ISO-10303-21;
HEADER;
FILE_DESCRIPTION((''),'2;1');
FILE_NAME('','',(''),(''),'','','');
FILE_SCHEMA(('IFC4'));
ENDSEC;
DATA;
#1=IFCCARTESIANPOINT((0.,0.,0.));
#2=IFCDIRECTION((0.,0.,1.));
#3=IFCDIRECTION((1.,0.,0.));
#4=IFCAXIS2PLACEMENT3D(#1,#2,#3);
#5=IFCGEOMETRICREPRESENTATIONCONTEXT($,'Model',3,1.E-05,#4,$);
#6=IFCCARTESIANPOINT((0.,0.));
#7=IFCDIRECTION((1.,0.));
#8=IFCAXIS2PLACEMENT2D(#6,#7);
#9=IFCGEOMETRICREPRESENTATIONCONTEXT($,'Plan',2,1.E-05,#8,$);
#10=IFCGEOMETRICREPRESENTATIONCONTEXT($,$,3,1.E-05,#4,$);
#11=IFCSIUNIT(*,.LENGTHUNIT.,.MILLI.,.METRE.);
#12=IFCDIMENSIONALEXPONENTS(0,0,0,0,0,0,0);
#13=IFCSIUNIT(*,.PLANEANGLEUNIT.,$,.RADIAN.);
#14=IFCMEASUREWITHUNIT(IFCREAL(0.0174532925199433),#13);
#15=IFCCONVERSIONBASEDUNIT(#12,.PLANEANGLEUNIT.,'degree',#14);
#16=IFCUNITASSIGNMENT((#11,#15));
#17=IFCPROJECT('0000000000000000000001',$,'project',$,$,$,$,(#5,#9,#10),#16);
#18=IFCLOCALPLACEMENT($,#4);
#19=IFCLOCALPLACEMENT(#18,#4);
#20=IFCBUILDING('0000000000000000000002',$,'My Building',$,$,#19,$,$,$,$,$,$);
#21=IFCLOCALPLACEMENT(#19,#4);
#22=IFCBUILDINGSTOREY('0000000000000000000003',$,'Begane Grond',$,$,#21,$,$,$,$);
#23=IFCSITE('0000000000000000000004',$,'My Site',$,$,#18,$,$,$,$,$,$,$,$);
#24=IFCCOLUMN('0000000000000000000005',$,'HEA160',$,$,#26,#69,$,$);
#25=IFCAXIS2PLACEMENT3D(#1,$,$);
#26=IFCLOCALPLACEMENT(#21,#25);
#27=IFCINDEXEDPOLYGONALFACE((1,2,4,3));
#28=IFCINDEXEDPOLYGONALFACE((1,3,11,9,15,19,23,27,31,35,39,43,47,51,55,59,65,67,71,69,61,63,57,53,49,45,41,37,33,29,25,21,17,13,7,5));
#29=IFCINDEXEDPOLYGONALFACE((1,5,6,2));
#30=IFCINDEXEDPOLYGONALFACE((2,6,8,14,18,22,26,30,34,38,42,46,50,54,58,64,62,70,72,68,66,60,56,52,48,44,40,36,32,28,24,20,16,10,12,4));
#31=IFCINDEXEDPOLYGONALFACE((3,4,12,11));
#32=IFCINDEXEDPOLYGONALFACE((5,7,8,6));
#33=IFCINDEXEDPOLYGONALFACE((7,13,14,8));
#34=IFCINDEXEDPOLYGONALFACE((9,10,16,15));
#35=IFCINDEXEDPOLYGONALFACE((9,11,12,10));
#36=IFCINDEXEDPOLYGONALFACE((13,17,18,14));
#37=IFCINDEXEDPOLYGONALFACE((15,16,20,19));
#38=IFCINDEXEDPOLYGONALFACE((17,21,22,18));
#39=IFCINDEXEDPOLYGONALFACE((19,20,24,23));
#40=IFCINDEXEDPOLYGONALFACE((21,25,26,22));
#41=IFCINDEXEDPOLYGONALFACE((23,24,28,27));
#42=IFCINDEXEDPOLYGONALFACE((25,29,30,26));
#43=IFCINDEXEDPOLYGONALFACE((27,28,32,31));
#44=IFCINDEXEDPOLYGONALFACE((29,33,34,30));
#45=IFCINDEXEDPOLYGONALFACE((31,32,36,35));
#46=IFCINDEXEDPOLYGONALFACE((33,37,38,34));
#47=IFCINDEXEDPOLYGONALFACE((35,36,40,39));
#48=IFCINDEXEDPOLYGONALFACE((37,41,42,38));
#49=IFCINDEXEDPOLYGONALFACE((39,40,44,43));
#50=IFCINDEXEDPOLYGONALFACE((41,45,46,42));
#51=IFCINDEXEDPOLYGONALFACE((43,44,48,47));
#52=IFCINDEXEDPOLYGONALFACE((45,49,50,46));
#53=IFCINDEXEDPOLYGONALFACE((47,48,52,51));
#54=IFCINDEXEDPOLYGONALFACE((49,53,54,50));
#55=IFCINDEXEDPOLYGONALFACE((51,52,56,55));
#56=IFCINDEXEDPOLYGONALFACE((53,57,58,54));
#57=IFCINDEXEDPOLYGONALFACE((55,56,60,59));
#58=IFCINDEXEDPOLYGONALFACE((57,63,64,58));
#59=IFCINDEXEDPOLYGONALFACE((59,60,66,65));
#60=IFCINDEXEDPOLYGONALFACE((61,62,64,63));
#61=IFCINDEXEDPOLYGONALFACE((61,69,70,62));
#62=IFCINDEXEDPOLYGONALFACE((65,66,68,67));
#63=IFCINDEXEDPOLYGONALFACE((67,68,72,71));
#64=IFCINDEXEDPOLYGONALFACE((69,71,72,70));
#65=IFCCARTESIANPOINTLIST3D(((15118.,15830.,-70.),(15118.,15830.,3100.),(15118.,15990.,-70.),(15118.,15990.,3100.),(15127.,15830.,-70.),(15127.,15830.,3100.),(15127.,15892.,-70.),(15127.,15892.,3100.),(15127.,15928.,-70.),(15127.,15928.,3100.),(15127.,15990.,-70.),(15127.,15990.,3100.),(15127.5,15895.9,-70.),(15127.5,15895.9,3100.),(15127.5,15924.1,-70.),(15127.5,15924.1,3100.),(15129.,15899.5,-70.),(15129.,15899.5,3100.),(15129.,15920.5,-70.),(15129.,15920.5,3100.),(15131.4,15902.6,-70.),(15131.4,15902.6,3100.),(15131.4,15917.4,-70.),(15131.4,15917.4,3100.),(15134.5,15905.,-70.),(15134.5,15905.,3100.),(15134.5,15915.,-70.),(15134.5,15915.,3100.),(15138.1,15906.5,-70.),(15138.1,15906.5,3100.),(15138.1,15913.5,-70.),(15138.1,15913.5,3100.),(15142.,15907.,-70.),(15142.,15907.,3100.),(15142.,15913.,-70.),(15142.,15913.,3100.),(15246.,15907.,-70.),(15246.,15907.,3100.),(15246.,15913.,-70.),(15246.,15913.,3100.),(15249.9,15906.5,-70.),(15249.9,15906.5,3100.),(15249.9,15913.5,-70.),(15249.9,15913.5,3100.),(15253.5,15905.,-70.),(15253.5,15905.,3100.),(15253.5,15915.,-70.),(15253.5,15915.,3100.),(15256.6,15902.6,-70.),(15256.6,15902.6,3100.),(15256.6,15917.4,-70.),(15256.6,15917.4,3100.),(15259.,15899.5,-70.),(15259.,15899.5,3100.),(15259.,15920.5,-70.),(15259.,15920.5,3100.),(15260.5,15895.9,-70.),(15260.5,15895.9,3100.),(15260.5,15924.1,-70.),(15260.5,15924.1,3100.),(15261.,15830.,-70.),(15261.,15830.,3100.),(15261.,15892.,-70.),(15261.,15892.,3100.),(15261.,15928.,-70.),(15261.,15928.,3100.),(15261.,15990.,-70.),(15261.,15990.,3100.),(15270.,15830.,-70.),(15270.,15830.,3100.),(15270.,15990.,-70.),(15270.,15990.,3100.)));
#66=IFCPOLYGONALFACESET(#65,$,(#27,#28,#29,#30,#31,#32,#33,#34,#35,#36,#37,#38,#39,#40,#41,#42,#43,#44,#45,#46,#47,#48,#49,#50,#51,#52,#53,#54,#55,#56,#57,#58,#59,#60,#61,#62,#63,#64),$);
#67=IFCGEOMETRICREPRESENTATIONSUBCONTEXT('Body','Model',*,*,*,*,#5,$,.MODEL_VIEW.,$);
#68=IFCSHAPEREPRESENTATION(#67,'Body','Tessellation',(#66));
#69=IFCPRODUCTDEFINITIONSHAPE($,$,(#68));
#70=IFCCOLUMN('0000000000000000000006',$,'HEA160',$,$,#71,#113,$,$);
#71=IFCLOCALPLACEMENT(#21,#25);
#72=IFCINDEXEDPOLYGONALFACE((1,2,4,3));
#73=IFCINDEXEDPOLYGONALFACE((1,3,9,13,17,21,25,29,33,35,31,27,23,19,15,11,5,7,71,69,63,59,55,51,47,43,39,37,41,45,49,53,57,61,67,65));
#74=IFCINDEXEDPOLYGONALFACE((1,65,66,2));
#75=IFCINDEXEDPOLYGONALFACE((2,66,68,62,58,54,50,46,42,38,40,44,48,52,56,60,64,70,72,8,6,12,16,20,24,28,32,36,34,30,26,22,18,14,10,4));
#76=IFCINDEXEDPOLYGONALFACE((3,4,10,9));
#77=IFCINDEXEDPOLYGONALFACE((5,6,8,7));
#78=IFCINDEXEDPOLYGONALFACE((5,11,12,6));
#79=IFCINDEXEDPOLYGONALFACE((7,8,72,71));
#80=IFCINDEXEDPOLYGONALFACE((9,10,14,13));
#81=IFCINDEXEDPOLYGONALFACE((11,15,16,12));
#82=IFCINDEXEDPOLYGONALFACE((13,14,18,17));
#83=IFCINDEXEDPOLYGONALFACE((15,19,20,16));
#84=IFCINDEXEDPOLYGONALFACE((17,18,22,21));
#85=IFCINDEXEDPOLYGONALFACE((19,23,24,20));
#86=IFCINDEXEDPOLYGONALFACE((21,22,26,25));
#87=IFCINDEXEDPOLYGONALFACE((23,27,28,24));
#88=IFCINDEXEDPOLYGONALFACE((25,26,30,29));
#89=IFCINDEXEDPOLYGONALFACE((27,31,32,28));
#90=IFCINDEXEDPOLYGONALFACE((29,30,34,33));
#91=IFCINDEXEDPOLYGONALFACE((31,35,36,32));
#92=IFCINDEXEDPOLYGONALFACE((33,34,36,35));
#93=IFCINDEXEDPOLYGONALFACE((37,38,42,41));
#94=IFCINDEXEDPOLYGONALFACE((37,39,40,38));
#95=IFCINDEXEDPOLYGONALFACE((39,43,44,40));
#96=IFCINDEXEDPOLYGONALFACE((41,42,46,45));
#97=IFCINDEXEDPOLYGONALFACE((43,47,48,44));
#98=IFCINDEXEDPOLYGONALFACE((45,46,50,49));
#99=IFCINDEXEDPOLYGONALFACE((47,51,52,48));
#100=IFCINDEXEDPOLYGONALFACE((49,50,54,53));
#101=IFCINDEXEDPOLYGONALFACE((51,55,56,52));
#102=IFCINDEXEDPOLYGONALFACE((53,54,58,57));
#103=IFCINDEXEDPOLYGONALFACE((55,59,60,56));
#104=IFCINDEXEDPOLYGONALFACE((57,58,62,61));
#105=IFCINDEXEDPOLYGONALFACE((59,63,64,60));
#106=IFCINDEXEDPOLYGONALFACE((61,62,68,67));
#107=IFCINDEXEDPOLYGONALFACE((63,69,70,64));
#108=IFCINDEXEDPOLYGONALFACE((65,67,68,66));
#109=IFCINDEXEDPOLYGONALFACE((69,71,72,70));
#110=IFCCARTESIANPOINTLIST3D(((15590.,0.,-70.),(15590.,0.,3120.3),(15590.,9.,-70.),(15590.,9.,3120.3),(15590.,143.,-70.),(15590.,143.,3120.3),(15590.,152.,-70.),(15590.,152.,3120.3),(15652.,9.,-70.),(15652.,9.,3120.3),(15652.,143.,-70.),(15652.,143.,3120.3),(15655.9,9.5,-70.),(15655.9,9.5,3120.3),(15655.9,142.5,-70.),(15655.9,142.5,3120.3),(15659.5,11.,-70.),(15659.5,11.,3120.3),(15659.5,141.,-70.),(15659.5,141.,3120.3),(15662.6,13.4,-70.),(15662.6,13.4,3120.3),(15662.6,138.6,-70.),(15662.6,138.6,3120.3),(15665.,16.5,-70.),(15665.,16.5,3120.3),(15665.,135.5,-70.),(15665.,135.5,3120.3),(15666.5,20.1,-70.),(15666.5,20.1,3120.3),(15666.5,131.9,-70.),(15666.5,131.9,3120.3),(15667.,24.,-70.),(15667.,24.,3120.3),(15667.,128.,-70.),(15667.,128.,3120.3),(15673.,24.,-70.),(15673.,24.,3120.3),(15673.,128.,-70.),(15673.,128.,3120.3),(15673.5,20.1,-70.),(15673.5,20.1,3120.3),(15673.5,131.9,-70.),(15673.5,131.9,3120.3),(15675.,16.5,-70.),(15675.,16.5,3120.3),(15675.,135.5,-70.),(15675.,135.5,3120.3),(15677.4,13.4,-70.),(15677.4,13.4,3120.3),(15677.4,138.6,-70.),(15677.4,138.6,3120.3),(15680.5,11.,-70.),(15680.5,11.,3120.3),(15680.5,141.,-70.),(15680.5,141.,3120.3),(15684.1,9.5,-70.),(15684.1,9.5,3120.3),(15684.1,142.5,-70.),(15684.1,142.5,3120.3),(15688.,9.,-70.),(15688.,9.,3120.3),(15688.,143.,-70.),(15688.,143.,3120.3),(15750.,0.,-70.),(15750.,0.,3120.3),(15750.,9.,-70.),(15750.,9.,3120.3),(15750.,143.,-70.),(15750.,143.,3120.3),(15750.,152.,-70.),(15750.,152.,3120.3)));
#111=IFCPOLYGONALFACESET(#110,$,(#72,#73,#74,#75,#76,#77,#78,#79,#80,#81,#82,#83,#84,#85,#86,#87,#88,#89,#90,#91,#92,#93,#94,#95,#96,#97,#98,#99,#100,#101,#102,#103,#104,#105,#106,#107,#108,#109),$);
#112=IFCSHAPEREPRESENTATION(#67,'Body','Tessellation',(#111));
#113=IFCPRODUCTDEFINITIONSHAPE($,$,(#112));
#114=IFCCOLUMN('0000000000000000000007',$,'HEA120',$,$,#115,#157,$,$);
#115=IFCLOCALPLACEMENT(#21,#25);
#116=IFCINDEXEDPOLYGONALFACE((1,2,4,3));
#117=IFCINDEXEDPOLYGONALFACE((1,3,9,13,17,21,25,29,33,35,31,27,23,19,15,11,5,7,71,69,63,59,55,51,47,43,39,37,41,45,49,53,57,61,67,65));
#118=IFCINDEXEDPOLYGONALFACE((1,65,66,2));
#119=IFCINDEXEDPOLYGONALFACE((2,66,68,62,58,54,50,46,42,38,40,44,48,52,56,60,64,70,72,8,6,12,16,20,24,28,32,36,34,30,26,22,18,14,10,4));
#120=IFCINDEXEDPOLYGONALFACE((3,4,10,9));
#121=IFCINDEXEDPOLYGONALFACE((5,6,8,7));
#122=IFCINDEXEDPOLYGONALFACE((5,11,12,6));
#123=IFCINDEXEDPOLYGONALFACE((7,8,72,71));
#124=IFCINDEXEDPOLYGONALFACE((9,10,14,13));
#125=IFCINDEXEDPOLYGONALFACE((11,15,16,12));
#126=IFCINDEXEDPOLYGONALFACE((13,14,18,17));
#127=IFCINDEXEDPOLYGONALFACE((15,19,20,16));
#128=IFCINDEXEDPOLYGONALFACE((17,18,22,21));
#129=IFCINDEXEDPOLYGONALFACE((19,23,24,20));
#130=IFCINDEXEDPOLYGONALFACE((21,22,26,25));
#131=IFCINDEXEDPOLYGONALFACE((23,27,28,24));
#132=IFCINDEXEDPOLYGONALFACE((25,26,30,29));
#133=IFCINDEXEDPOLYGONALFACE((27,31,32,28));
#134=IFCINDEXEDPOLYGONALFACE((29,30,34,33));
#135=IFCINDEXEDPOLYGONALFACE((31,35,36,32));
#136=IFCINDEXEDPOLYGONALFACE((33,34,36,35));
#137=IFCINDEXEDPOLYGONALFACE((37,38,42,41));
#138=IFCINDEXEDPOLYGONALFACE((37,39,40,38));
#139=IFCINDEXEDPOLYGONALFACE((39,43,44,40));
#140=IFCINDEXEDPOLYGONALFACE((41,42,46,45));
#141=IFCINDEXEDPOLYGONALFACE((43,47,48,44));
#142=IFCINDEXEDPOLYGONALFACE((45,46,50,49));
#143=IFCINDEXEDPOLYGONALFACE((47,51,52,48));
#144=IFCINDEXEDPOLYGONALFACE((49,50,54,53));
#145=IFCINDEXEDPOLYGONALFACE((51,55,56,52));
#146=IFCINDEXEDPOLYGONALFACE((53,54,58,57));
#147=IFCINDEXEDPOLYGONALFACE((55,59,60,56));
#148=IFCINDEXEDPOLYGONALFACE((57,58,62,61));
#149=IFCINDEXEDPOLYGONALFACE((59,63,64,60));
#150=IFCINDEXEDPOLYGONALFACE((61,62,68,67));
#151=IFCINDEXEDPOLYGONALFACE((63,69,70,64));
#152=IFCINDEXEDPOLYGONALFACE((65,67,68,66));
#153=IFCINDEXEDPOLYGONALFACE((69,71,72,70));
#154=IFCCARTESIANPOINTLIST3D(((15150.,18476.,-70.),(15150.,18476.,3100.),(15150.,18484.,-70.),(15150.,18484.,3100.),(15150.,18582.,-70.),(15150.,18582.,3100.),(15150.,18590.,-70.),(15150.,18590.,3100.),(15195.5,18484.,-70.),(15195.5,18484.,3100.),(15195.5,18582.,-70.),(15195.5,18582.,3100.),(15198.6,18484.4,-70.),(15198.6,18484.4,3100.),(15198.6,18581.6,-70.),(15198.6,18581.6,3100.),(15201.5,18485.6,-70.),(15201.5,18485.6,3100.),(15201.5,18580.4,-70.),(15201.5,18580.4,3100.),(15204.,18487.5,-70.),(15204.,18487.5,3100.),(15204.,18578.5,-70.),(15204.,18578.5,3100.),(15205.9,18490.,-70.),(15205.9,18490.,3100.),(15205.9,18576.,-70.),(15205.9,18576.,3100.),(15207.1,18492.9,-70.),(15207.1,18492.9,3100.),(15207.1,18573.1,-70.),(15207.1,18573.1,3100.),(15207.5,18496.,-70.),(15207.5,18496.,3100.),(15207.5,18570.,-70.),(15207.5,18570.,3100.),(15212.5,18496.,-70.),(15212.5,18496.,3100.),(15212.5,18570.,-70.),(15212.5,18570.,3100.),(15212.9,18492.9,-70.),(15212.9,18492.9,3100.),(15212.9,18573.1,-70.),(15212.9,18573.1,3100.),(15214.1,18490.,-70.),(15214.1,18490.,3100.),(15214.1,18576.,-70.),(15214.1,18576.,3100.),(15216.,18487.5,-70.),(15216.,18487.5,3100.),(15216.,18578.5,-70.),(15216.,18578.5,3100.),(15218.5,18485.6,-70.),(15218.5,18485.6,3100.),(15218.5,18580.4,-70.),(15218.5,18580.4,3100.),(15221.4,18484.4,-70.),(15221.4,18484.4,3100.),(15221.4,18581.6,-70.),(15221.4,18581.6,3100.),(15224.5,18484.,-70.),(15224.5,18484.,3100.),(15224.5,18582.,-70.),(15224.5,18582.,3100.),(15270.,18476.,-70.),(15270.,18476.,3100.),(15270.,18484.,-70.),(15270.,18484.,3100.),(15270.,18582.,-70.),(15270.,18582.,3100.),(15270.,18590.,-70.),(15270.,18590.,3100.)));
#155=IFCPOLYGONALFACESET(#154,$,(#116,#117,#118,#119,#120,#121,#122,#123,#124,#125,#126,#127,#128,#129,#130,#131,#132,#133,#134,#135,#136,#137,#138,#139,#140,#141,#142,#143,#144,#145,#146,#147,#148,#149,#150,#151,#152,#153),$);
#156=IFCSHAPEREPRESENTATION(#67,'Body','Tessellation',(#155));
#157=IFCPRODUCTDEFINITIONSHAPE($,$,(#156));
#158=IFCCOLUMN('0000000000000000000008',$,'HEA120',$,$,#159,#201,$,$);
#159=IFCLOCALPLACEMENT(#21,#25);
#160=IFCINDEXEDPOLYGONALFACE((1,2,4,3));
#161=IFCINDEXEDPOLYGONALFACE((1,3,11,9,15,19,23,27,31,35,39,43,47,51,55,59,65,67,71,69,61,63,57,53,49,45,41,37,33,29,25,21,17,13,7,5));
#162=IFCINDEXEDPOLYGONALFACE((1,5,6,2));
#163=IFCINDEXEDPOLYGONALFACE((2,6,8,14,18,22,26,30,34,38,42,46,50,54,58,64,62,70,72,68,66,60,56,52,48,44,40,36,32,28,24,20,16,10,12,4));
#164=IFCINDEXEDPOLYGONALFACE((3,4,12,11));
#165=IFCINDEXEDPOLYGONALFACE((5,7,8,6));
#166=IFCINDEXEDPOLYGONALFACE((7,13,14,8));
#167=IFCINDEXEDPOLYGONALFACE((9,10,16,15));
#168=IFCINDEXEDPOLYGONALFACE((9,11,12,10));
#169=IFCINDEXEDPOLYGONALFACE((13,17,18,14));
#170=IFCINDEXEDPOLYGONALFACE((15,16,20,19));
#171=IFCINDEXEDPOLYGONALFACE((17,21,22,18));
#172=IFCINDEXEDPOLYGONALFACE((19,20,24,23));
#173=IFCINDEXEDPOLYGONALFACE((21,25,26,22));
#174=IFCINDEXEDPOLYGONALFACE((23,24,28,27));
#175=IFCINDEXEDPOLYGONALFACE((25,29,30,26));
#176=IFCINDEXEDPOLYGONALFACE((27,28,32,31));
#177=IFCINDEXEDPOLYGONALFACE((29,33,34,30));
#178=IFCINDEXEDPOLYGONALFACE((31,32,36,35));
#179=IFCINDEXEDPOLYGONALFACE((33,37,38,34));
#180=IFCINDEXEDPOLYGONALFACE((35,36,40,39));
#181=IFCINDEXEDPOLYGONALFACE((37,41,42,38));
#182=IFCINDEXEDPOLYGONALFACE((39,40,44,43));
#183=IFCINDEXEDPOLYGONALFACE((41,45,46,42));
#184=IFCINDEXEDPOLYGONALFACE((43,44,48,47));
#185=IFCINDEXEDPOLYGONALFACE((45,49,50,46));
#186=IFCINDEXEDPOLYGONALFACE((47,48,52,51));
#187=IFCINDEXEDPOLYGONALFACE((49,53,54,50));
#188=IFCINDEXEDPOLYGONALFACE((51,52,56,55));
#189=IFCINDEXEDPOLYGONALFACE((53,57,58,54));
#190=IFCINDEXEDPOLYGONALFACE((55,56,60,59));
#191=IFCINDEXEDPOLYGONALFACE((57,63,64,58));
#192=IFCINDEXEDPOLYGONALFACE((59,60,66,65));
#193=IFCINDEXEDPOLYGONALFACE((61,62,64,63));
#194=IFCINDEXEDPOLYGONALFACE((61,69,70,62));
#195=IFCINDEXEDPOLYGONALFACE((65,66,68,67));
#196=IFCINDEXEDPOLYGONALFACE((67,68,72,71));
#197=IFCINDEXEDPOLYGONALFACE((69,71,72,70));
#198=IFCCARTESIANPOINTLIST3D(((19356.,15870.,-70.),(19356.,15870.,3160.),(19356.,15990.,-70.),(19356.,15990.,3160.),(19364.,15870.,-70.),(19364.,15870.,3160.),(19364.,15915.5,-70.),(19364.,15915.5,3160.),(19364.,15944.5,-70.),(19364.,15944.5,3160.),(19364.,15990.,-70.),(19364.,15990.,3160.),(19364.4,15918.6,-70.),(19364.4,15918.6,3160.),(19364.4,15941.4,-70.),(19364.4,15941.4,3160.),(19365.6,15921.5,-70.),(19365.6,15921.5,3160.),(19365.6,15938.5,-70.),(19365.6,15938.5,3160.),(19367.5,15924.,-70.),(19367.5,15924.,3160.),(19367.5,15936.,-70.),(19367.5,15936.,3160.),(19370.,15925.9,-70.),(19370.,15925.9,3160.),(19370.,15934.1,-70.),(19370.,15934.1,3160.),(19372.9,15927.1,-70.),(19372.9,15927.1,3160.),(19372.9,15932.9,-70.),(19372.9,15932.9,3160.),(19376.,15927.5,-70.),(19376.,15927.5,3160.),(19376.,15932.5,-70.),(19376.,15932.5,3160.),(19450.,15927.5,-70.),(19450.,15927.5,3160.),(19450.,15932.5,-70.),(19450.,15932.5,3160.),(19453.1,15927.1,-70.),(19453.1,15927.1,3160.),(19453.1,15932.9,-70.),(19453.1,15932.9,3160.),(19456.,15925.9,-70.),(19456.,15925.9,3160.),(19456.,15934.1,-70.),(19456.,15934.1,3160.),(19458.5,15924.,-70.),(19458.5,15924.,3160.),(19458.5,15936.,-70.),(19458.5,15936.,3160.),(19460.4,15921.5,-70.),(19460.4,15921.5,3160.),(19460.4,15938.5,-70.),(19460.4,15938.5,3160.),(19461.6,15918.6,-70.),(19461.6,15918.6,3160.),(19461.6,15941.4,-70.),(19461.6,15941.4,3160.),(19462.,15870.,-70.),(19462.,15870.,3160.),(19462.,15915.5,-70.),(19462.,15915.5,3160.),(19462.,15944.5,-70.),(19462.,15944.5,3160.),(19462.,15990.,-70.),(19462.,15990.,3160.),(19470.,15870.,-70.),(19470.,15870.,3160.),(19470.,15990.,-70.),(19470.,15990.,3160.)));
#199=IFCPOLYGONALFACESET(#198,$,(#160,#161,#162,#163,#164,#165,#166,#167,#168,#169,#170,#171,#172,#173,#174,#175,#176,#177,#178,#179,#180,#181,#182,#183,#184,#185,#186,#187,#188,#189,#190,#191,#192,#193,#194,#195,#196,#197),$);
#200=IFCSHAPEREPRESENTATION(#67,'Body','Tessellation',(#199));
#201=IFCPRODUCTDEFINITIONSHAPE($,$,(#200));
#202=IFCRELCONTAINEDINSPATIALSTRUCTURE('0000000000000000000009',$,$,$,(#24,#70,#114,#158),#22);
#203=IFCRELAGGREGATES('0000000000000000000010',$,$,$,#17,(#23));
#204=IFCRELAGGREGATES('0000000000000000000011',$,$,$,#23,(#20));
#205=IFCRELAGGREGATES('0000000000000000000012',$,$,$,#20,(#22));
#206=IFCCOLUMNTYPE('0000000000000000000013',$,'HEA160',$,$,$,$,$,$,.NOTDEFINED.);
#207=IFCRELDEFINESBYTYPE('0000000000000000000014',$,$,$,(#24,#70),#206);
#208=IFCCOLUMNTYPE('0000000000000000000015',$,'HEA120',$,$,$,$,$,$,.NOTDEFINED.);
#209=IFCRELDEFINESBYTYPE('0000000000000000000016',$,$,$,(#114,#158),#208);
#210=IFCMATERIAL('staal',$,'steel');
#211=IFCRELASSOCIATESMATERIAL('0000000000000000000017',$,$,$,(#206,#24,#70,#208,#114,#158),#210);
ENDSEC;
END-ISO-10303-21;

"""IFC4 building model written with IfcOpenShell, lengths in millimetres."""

from ifc_helpers import new_model, entity, si_unit, converted_unit, frame, origin_with_axes, origin_2d_with_axis, place, context, subcontext, project, spatial, i_section, extrude, material, material_profile, profile_set, profile_usage, type_object, element, save


model = new_model("IFC4")

# Units and contexts
model_context = context("Model", 3, precision=1e-05, world=origin_with_axes())
plan_context = context("Plan", 2, precision=1e-05, world=origin_2d_with_axis())
context_of_model = context(None, 3, precision=1e-05, world=origin_with_axes())
body_context = subcontext(model_context, "Body", "Model", "MODEL_VIEW")
ifc_project = project(units=[si_unit("LENGTHUNIT", "METRE", prefix="MILLI"), converted_unit("PLANEANGLEUNIT", "degree", entity("IfcReal", 0.0174532925199433), si_unit("PLANEANGLEUNIT", "RADIAN"), dimensions=[0, 0, 0, 0, 0, 0, 0])], contexts=[model_context, plan_context, context_of_model])

# Site, building, storey
site_placement = place(None, origin_with_axes())
site = spatial("IfcSite", under=ifc_project, at=site_placement, Name="My Site")
building_placement = place(site_placement, origin_with_axes())
building = spatial("IfcBuilding", under=site, at=building_placement, Name="My Building")
storey_placement = place(building_placement, origin_with_axes())
storey = spatial("IfcBuildingStorey", under=building, at=storey_placement, Name="Begane Grond")

# Columns
ifc_material = material(Name="staal", Category="steel")
ifc_material_profile_1 = material_profile(ifc_material, i_section(OverallWidth=160.0, OverallDepth=152.0, WebThickness=6.0, FlangeThickness=9.0, FilletRadius=15.0))
ifc_profile_set_1 = profile_set([ifc_material_profile_1], Name="HEA160")
column_type_1 = type_object("IfcColumnType", Name="HEA160", PredefinedType="NOTDEFINED", material=ifc_profile_set_1)
ifc_profile_usage_1 = profile_usage(ifc_profile_set_1)
column_1_placement = place(storey_placement, frame((15194.0, 15910.0, -70.0), z_axis=(0.0, 0.0, 1.0), x_axis=(0.0, 1.0, 0.0)))
element("IfcColumn", 1, at=column_1_placement, inside=storey, type_object=column_type_1, material=ifc_profile_usage_1, Name="HEA160", context=body_context, shape_type="SweptSolid", body=[
    extrude(i_section(OverallWidth=160.0, OverallDepth=152.0, WebThickness=6.0, FlangeThickness=9.0, FilletRadius=15.0), origin_with_axes(), (0.0, 0.0, 1.0), 3170.0),
])
ifc_profile_usage_2 = profile_usage(ifc_profile_set_1)
column_2_placement = place(storey_placement, frame((15670.0, 76.0, -70.0), z_axis=(0.0, 0.0, 1.0), x_axis=(-1.0, 0.0, 0.0)))
element("IfcColumn", 2, at=column_2_placement, inside=storey, type_object=column_type_1, material=ifc_profile_usage_2, Name="HEA160", context=body_context, shape_type="SweptSolid", body=[
    extrude(i_section(OverallWidth=160.0, OverallDepth=152.0, WebThickness=6.0, FlangeThickness=9.0, FilletRadius=15.0), origin_with_axes(), (0.0, 0.0, 1.0), 3190.3),
])
ifc_material_profile_2 = material_profile(ifc_material, i_section(OverallWidth=120.0, OverallDepth=114.0, WebThickness=5.0, FlangeThickness=8.0, FilletRadius=12.0))
ifc_profile_set_2 = profile_set([ifc_material_profile_2], Name="HEA120")
ifc_profile_usage_3 = profile_usage(ifc_profile_set_2)
column_type_2 = type_object("IfcColumnType", Name="HEA120", PredefinedType="NOTDEFINED", material=ifc_profile_set_2)
column_3_placement = place(storey_placement, frame((15210.0, 18533.0, -70.0), z_axis=(0.0, 0.0, 1.0), x_axis=(1.0, 0.0, 0.0)))
element("IfcColumn", 3, at=column_3_placement, inside=storey, type_object=column_type_2, material=ifc_profile_usage_3, Name="HEA120", context=body_context, shape_type="SweptSolid", body=[
    extrude(i_section(OverallWidth=120.0, OverallDepth=114.0, WebThickness=5.0, FlangeThickness=8.0, FilletRadius=12.0), origin_with_axes(), (0.0, 0.0, 1.0), 3170.0),
])
ifc_profile_usage_4 = profile_usage(ifc_profile_set_2)
column_4_placement = place(storey_placement, frame((19413.0, 15930.0, -70.0), z_axis=(0.0, 0.0, 1.0), x_axis=(0.0, 1.0, 0.0)))
element("IfcColumn", 4, at=column_4_placement, inside=storey, type_object=column_type_2, material=ifc_profile_usage_4, Name="HEA120", context=body_context, shape_type="SweptSolid", body=[
    extrude(i_section(OverallWidth=120.0, OverallDepth=114.0, WebThickness=5.0, FlangeThickness=8.0, FilletRadius=12.0), origin_with_axes(), (0.0, 0.0, 1.0), 3230.0),
])

save(model, "model.ifc")
